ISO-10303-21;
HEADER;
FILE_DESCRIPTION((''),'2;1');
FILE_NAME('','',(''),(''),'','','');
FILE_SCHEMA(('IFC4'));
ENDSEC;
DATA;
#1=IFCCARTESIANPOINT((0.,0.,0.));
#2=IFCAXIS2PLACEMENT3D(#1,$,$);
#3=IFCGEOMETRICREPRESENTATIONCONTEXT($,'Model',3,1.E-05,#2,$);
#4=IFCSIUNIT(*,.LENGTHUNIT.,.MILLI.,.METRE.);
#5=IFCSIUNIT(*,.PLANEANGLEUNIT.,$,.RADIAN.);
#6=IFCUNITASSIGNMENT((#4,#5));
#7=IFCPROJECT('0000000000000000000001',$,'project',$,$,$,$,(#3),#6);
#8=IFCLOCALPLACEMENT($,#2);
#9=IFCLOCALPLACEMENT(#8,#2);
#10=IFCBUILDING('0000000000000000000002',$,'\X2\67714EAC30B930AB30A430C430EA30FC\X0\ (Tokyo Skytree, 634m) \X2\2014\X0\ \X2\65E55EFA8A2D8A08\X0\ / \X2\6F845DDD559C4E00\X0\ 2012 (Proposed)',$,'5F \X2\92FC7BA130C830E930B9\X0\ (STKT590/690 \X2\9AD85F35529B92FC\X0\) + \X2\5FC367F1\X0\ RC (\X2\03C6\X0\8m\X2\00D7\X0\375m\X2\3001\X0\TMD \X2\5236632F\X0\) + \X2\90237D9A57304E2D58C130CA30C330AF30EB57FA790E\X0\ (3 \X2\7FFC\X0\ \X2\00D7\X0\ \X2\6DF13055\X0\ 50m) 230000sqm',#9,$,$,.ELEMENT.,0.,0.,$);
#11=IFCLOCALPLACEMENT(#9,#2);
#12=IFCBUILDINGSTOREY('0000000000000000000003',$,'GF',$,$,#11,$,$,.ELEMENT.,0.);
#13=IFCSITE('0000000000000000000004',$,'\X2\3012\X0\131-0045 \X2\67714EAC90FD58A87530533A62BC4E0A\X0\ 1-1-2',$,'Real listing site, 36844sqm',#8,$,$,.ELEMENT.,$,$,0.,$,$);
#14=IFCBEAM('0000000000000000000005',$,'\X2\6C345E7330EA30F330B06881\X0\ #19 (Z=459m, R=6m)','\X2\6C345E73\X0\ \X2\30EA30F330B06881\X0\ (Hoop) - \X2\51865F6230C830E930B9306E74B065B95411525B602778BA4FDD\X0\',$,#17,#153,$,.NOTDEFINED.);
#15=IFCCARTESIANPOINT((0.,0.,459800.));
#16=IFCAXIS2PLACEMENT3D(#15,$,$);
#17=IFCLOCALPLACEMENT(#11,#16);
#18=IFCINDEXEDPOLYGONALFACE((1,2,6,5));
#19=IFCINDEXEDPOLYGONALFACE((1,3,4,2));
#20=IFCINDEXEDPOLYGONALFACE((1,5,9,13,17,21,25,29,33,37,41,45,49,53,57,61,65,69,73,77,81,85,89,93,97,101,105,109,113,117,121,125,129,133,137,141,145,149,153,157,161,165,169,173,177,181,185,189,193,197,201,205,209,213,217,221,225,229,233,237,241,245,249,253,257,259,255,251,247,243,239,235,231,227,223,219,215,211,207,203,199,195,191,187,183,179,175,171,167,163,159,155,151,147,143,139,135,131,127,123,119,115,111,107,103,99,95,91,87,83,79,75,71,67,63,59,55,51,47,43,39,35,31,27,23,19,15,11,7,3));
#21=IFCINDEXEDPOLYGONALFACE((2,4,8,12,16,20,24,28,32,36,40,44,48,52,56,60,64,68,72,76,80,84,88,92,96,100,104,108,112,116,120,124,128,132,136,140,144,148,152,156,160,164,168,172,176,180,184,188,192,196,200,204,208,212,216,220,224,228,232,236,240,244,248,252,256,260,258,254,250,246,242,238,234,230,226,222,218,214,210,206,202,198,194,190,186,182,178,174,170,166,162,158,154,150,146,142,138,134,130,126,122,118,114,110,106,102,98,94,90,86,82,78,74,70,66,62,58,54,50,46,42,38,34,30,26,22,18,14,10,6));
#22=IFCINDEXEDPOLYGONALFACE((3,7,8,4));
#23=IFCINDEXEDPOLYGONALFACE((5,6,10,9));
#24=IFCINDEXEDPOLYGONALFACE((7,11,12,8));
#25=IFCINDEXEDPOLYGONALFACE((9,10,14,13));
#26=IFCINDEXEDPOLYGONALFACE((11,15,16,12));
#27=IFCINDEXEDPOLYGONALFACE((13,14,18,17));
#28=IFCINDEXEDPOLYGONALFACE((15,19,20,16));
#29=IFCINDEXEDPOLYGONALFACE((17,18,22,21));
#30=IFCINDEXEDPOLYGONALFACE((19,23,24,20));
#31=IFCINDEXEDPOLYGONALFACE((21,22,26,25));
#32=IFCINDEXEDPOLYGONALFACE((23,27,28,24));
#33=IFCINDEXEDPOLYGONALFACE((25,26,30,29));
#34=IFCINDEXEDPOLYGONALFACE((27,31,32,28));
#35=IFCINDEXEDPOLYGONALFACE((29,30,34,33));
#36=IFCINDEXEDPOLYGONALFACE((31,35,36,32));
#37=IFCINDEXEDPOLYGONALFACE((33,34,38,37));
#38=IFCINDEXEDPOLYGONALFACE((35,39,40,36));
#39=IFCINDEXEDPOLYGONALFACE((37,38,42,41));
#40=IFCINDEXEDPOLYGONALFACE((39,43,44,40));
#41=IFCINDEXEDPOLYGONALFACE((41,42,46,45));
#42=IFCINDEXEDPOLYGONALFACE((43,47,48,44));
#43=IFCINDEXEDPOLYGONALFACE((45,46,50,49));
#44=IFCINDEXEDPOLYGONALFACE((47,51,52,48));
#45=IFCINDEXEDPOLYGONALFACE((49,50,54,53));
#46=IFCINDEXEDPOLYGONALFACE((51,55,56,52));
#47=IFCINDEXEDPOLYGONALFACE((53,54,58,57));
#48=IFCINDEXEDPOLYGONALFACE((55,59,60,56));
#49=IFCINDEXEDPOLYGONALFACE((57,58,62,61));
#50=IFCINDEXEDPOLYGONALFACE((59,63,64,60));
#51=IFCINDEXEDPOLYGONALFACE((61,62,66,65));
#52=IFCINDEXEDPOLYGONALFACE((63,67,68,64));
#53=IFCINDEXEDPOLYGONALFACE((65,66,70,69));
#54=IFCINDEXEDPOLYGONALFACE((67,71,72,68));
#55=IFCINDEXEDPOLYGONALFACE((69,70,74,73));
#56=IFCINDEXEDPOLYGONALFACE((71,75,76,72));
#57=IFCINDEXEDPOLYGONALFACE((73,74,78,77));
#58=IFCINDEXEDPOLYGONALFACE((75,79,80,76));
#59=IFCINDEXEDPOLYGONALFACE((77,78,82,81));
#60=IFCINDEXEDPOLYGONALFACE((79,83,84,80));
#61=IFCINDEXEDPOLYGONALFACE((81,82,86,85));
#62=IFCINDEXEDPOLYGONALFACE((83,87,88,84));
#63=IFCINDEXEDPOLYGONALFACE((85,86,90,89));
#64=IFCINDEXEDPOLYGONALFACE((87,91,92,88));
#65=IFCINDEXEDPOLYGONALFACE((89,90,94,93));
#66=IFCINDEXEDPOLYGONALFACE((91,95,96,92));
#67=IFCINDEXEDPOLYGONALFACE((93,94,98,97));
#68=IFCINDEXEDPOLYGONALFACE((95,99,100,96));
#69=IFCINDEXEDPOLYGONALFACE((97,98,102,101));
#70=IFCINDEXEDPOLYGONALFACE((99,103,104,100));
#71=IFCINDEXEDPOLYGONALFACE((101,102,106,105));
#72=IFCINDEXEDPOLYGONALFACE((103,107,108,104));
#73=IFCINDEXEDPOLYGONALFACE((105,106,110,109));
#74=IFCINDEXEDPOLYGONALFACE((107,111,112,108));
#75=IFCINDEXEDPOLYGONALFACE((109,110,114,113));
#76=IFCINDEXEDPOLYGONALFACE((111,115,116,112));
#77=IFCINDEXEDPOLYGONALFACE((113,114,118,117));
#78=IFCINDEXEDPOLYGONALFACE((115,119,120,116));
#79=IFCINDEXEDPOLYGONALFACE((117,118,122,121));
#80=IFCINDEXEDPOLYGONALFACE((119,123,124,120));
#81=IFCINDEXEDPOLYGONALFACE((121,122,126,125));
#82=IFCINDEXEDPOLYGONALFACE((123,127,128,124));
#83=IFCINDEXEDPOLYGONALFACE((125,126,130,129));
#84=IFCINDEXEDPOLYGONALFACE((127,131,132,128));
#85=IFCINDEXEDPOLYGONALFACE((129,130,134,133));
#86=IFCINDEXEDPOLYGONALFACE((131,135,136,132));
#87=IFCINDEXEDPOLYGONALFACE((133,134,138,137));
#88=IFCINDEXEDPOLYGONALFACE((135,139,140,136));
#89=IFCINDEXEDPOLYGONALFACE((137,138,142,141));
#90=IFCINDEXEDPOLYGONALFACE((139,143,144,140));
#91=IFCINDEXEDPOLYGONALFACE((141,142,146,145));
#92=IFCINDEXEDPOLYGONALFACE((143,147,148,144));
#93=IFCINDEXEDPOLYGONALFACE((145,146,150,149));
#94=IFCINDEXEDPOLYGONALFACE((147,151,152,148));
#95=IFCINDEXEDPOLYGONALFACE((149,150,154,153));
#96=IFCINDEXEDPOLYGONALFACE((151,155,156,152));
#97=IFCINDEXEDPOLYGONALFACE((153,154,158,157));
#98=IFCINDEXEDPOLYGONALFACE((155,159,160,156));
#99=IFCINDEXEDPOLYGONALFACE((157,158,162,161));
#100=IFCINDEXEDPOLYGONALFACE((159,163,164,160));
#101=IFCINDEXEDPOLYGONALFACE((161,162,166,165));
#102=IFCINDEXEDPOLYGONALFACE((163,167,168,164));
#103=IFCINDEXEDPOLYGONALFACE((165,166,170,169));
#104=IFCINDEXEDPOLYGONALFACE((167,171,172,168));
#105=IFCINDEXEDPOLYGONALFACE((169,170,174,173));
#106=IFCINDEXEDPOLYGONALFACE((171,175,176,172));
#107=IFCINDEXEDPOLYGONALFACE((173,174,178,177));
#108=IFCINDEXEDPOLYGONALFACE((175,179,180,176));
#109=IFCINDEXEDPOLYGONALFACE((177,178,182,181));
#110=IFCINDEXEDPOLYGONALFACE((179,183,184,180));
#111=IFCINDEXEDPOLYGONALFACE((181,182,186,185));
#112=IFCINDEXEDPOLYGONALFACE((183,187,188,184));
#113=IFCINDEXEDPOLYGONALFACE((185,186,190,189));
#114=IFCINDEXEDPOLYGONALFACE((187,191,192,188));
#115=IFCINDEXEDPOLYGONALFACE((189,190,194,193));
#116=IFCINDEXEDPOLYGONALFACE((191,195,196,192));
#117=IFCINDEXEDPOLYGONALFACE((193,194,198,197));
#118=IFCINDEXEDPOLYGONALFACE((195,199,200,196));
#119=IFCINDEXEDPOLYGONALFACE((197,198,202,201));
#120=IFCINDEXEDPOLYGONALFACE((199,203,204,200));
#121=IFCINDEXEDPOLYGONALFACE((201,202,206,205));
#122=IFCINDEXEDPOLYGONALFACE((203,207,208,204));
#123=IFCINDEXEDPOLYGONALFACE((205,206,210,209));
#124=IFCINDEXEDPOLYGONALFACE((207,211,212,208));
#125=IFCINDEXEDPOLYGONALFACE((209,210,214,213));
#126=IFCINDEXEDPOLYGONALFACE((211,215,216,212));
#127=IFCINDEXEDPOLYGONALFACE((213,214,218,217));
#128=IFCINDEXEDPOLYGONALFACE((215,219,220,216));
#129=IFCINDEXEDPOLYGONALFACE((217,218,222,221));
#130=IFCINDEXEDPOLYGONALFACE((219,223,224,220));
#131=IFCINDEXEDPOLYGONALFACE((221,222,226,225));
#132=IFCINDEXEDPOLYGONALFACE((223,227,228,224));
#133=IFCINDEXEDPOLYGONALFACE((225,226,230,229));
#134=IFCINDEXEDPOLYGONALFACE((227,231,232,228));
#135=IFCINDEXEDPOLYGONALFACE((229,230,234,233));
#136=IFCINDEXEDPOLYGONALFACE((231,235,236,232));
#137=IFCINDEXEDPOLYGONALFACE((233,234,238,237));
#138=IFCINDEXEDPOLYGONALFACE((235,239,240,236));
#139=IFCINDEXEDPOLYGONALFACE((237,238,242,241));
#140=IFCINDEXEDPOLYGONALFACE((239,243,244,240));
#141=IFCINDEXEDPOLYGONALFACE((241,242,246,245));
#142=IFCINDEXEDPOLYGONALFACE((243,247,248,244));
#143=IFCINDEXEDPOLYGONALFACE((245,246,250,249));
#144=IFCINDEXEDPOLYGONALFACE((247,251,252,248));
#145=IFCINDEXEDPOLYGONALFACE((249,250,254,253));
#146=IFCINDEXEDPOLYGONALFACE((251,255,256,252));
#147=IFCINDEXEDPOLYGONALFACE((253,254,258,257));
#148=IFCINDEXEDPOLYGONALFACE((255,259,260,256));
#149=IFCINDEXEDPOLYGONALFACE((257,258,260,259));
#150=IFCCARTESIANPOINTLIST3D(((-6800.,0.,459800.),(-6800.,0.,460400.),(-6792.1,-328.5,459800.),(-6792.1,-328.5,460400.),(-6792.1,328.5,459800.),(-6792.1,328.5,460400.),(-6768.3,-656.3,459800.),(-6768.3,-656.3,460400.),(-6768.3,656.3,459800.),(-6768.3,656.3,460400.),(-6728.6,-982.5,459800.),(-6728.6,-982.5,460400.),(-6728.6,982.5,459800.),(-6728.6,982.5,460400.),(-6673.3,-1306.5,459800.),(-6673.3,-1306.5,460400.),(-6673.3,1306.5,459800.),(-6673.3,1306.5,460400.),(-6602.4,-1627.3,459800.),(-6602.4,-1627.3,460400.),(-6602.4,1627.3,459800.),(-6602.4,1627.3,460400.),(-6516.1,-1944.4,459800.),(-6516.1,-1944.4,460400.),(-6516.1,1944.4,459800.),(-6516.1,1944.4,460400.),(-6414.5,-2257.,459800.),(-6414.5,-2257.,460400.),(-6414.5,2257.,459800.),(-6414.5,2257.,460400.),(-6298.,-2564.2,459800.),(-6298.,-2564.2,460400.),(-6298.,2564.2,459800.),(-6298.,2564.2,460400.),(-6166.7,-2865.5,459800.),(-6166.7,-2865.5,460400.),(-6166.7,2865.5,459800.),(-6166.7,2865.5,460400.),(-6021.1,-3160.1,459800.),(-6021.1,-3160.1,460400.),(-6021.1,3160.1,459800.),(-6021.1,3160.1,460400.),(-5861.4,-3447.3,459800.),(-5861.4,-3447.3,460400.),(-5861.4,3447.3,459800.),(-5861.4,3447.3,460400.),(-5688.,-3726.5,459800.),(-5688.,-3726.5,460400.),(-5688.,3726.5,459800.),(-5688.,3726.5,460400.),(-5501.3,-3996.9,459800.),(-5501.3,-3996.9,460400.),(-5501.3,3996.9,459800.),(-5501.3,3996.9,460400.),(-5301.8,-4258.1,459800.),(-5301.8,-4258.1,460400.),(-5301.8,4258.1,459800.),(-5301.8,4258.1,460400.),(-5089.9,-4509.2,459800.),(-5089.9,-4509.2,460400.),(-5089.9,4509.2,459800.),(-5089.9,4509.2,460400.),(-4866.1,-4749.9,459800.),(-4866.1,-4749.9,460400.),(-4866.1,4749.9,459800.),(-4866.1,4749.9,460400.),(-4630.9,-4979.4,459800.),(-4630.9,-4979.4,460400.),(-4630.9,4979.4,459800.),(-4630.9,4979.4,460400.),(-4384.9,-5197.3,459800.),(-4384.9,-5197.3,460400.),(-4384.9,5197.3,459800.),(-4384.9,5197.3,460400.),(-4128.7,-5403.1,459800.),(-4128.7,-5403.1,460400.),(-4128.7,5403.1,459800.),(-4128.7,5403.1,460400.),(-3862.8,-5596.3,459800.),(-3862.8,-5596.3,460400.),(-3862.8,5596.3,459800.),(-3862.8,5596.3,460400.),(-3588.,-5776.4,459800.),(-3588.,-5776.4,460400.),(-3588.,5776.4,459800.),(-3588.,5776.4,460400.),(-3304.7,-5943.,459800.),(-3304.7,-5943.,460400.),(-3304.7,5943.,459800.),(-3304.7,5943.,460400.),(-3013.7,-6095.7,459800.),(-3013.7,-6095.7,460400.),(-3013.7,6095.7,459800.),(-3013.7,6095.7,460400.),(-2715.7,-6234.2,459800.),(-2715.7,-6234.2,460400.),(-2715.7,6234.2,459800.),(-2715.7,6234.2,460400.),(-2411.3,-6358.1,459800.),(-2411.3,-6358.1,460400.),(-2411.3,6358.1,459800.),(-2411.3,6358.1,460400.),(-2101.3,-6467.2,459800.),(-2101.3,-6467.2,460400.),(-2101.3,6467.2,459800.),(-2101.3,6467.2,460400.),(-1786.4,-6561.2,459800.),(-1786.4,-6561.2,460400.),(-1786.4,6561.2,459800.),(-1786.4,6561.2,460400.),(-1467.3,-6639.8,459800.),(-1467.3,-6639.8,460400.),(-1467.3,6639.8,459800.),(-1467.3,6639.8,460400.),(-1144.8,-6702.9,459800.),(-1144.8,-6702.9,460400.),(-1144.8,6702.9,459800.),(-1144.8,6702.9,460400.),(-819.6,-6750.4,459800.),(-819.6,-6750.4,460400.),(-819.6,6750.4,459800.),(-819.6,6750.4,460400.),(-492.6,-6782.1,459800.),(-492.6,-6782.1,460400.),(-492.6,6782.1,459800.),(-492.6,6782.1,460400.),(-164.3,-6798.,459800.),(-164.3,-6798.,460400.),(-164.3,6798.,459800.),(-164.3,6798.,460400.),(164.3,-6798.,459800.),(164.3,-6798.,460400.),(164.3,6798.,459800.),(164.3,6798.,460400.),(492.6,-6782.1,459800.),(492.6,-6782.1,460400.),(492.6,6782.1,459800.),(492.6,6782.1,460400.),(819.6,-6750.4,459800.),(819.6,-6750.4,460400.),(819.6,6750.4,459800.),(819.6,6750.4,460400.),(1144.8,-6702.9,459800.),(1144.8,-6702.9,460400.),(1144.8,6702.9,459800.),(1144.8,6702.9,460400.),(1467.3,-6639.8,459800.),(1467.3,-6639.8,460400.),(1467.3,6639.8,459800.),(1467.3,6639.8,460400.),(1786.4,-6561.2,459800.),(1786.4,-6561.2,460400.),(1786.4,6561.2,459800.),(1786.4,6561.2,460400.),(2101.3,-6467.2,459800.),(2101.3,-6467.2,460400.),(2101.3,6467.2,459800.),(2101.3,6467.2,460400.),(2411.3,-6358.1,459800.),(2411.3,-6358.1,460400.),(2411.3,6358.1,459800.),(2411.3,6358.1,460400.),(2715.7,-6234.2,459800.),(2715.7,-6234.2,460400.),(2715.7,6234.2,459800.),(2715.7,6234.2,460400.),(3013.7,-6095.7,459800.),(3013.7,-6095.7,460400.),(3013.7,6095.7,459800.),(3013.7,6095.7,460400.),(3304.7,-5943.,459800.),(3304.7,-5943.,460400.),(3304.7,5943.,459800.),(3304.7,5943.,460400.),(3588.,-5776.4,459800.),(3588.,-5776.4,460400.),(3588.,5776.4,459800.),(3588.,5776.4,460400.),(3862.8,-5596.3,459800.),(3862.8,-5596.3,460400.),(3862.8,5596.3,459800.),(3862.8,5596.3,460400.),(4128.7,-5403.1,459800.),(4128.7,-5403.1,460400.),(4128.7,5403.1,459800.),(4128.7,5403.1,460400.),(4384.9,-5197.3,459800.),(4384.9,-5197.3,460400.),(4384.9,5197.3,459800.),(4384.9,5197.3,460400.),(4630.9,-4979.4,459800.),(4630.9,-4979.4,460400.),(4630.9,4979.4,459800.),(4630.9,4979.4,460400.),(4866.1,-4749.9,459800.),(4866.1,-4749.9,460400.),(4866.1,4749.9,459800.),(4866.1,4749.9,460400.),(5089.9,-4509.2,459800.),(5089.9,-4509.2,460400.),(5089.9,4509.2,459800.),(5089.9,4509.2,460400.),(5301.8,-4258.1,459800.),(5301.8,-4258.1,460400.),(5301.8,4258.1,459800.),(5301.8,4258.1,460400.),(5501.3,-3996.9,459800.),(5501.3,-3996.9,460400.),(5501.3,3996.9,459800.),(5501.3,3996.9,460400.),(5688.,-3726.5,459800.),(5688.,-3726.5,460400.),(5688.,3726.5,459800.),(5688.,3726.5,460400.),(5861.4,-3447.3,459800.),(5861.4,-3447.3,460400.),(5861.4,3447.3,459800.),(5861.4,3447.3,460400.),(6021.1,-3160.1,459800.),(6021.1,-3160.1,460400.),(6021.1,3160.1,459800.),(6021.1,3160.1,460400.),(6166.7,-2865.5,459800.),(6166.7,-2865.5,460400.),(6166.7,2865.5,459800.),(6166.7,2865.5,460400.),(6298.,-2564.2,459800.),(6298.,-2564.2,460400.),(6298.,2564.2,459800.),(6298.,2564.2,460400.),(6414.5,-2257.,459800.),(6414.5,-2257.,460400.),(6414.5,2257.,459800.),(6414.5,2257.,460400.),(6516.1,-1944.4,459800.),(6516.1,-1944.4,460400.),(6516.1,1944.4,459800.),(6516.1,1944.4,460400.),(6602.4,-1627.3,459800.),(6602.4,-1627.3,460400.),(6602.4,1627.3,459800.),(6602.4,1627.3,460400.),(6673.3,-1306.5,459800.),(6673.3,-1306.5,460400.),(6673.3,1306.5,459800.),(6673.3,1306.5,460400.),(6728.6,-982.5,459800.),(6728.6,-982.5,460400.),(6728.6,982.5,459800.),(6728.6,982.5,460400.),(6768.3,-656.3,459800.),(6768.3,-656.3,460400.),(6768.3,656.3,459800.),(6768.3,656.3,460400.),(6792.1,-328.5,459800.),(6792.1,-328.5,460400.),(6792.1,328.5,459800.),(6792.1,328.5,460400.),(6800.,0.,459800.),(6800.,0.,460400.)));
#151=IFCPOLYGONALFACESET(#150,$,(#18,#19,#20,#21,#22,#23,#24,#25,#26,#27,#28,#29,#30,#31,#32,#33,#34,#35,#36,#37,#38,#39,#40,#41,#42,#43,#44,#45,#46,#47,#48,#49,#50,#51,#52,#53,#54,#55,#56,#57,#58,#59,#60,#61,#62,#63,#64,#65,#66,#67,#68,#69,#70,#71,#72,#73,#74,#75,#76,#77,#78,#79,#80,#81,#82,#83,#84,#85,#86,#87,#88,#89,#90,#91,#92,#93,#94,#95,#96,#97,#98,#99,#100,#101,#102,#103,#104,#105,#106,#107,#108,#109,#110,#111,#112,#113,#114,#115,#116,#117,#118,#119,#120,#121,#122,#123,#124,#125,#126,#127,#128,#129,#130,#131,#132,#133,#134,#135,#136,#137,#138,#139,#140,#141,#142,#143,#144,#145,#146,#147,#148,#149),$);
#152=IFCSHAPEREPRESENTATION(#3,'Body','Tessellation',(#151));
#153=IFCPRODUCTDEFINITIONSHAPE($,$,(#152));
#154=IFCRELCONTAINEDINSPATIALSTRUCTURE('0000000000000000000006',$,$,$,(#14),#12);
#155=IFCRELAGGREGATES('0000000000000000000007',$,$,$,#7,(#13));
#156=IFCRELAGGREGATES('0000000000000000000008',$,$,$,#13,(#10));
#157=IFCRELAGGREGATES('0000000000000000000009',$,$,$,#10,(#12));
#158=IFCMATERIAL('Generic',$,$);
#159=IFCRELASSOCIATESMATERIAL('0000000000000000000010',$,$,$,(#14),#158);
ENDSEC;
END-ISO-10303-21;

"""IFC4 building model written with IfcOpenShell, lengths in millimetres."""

from ifc_helpers import new_model, si_unit, frame, origin, origin_2d, place, context, project, spatial, circle, extrude, material, element, save


model = new_model("IFC4")

# Units and contexts
model_context = context("Model", 3, precision=1e-05, world=origin())
ifc_project = project(units=[si_unit("LENGTHUNIT", "METRE", prefix="MILLI"), si_unit("PLANEANGLEUNIT", "RADIAN")], contexts=[model_context])

# Site, building, storey
site_placement = place(None, origin())
site = spatial("IfcSite", under=ifc_project, at=site_placement, Name="〒131-0045 東京都墨田区押上 1-1-2", ObjectType="Real listing site, 36844sqm", CompositionType="ELEMENT", RefElevation=0.0)
building_placement = place(site_placement, origin())
building = spatial("IfcBuilding", under=site, at=building_placement, Name="東京スカイツリー (Tokyo Skytree, 634m) — 日建設計 / 澄川喜一 2012 (Proposed)", ObjectType="5F 鋼管トラス (STKT590/690 高張力鋼) + 心柱 RC (φ8m×375m、TMD 制振) + 連続地中壁ナックル基礎 (3 翼 × 深さ 50m) 230000sqm", CompositionType="ELEMENT", ElevationOfRefHeight=0.0, ElevationOfTerrain=0.0)
storey_placement = place(building_placement, origin())
storey = spatial("IfcBuildingStorey", under=building, at=storey_placement, Name="GF", CompositionType="ELEMENT", Elevation=0.0)

# Shared definitions
ifc_material = material(Name="Generic")

# Beam
beam_1_placement = place(storey_placement, frame((0.0, 0.0, 459800.0)))
element("IfcBeam", 1, at=beam_1_placement, inside=storey, material=ifc_material, Name="水平リング梁 #19 (Z=459m, R=6m)", Description="水平 リング梁 (Hoop) - 円形トラスの環方向剛性確保", PredefinedType="NOTDEFINED", context=model_context, shape_type="SweptSolid", body=[
    extrude(circle(Radius=6800.0, at=origin_2d()), frame((0.0, 0.0, 459800.0)), (0.0, 0.0, 1.0), 600.0),
])

save(model, "model.ifc")
